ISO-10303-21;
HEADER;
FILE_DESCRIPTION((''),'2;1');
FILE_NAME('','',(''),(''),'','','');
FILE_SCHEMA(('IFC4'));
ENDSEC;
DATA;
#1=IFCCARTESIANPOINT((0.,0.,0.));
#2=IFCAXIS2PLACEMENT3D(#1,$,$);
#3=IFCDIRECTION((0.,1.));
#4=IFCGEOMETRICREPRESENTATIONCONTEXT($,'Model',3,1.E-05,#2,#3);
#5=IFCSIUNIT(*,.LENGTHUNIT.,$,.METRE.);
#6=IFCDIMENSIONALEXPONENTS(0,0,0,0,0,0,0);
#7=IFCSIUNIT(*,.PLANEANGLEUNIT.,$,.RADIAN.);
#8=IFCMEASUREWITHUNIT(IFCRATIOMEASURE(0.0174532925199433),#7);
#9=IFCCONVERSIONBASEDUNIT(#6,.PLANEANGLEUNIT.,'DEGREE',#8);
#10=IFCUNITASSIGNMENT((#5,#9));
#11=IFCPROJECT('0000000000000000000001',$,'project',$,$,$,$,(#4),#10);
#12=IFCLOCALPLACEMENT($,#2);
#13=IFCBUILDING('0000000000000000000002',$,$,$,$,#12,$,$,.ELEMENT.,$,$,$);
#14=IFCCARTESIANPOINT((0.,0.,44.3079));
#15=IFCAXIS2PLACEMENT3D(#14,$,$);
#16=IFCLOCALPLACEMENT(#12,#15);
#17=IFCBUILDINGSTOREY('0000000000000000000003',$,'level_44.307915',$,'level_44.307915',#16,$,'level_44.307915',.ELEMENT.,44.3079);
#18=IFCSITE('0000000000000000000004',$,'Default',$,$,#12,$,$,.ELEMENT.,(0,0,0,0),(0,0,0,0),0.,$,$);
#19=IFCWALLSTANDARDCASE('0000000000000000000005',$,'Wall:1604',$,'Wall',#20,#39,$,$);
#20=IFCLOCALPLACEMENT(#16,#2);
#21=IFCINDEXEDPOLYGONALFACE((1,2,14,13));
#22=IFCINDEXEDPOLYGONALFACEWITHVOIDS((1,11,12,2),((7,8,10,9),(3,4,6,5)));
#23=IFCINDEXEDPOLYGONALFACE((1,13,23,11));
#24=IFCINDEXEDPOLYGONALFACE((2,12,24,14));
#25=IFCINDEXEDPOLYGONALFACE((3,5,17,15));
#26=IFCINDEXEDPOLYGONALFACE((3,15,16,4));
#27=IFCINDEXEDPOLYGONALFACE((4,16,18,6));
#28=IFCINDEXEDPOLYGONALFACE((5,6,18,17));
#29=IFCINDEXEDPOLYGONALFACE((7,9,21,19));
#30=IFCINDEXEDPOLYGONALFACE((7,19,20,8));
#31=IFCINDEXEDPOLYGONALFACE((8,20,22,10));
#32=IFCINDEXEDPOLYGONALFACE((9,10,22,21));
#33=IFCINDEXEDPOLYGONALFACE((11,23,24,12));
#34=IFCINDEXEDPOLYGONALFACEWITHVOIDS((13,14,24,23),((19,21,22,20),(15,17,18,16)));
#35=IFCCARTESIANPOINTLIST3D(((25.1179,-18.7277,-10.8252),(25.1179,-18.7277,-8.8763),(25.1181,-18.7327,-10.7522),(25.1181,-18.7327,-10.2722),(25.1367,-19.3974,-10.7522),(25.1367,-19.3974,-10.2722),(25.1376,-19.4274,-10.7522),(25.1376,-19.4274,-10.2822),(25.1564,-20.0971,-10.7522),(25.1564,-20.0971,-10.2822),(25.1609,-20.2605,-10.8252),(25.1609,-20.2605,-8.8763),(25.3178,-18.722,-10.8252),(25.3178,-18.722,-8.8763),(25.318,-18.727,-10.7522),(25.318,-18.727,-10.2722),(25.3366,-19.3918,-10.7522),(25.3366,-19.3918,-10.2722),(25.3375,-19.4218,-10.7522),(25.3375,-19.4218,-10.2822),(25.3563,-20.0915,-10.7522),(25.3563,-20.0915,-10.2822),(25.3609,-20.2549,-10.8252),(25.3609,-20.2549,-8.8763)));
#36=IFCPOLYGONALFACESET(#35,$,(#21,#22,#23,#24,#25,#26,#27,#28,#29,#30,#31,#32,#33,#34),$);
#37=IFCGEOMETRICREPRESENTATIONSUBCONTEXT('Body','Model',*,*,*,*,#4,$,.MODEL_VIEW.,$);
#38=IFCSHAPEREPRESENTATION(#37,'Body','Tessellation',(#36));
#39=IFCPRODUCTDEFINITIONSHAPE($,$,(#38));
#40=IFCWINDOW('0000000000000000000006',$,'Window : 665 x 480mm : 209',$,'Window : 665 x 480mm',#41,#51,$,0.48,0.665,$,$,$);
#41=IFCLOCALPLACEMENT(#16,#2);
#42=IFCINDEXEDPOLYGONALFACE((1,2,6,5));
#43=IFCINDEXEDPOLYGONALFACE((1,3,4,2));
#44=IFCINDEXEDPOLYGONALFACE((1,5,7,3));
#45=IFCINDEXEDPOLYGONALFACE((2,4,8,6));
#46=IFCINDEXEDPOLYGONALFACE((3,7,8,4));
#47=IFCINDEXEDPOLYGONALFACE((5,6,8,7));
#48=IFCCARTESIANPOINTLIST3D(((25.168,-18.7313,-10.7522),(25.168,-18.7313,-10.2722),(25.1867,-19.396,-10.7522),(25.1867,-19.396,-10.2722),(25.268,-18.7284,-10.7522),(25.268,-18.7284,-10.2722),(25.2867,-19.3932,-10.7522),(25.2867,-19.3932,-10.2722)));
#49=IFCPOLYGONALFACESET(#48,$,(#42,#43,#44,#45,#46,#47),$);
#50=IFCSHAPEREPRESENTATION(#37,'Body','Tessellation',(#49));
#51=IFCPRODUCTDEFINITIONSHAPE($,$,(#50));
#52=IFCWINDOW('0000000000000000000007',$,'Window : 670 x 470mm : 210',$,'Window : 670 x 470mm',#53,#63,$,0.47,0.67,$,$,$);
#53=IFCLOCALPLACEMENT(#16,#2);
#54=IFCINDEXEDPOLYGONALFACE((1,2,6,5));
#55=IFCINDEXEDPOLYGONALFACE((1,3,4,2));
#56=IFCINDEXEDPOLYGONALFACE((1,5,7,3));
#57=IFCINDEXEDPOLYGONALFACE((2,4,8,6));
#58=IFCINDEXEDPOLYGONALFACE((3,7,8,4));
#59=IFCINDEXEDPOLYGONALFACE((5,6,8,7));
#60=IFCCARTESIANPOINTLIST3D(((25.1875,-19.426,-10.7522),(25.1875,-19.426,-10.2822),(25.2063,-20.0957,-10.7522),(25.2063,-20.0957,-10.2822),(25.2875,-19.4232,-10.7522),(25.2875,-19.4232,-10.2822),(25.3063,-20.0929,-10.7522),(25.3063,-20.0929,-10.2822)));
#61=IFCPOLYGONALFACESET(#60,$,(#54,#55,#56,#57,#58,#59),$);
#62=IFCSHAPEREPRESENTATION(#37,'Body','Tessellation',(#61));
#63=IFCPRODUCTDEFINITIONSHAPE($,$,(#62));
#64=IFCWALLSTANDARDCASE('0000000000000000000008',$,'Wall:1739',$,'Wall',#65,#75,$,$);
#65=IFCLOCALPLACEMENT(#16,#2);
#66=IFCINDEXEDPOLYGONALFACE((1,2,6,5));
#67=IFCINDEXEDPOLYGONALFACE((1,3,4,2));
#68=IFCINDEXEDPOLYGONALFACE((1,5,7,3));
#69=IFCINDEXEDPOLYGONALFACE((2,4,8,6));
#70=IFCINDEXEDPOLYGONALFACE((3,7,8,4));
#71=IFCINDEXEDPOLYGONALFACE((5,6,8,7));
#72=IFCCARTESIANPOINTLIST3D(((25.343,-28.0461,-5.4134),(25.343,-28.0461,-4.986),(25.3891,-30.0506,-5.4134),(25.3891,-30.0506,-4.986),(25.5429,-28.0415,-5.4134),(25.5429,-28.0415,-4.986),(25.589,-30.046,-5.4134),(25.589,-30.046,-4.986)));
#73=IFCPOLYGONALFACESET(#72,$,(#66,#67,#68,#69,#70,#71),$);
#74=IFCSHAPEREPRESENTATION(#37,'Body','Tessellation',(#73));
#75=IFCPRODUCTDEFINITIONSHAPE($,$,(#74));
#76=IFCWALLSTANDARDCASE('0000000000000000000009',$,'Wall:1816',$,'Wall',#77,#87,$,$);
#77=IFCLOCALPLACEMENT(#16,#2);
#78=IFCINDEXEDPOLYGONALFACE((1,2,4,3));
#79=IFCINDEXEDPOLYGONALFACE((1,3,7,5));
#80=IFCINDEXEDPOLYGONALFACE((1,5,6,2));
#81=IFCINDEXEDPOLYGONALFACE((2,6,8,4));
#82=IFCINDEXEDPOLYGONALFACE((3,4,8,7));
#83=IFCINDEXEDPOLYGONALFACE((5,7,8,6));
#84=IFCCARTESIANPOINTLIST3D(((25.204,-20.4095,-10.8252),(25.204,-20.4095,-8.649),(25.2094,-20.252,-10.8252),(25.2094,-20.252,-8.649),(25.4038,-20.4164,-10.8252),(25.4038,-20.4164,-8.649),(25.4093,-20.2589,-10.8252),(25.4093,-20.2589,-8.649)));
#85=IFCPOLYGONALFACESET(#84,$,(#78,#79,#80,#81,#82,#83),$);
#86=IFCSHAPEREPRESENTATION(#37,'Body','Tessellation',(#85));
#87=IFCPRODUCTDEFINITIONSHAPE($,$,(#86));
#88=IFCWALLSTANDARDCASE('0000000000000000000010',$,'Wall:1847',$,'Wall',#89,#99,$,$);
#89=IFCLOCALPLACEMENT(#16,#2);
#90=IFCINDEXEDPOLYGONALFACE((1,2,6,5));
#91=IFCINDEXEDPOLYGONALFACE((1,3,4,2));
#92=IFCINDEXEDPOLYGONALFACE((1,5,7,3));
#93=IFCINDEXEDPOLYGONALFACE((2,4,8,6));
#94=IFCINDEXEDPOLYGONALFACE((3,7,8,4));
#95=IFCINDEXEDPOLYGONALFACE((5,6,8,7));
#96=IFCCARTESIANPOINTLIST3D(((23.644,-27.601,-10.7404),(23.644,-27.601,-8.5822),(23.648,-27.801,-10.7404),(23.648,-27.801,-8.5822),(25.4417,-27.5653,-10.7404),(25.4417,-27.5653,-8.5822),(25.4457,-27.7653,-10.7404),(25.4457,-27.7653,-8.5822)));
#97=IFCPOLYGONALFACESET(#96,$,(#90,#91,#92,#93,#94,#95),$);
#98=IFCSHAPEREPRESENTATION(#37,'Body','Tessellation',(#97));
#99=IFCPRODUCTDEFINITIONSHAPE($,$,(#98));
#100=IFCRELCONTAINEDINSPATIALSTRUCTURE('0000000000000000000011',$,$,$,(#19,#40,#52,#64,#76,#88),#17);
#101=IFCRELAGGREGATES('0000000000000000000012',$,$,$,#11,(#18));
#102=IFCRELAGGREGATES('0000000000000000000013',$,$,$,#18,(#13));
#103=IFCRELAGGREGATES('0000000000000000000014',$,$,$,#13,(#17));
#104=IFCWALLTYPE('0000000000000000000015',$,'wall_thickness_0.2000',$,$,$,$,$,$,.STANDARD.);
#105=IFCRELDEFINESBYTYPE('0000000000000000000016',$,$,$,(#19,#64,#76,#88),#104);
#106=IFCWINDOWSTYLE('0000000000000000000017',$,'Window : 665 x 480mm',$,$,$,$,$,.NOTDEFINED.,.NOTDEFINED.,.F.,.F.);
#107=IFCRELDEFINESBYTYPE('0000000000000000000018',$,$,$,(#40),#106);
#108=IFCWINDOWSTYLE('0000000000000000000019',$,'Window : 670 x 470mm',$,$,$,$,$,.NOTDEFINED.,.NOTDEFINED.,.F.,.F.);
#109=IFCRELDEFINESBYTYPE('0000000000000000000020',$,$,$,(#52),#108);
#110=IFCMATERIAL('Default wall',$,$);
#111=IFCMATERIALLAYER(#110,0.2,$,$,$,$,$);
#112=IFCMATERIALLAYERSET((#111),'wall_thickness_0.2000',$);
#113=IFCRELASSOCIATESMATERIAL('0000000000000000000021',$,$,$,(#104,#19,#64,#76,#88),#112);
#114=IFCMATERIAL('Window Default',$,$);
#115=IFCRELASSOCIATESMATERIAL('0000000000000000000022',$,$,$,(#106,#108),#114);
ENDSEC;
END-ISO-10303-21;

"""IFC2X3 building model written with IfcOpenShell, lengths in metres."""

from ifc_helpers import new_model, entity, si_unit, converted_unit, direction, frame, frame_2d, origin, origin_2d_with_axis, place, context, subcontext, project, spatial, polyline, rectangle, outline, extrude, source, transform, mapped, material, layer, layer_set, layer_usage, type_object, type_shapes, element, fill, save


model = new_model("IFC2X3")

# Units and contexts
model_context = context("Model", 3, precision=1e-05, world=origin(), true_north=direction((0.0, 1.0)))
body_context = subcontext(model_context, "Body", "Model", "MODEL_VIEW")
ifc_project = project(units=[si_unit("LENGTHUNIT", "METRE"), converted_unit("PLANEANGLEUNIT", "DEGREE", entity("IfcRatioMeasure", 0.0174532925199433), si_unit("PLANEANGLEUNIT", "RADIAN"), dimensions=[0, 0, 0, 0, 0, 0, 0])], contexts=[model_context])

# Site, building, storey
placement_1 = place(None, origin())
site = spatial("IfcSite", under=ifc_project, at=placement_1, Name="Default", CompositionType="ELEMENT", RefLatitude=(0, 0, 0, 0), RefLongitude=(0, 0, 0, 0), RefElevation=0.0)
building = spatial("IfcBuilding", under=site, at=placement_1, CompositionType="ELEMENT")
storey_placement = place(placement_1, frame((0.0, 0.0, 44.3079)))
storey = spatial("IfcBuildingStorey", under=building, at=storey_placement, Name="level_44.307915", ObjectType="level_44.307915", LongName="level_44.307915", CompositionType="ELEMENT", Elevation=44.3079)

# Shared definitions
ifc_material_1 = material(Name="Default wall")
ifc_layer = layer(ifc_material_1, 0.2)
ifc_layer_set = layer_set([ifc_layer], Name="wall_thickness_0.2000")
ifc_layer_usage = layer_usage(ifc_layer_set, "AXIS2", "POSITIVE", -0.1)
wall_type = type_object("IfcWallType", Name="wall_thickness_0.2000", PredefinedType="STANDARD", material=ifc_layer_set)

# Shared definitions
ifc_material_2 = material(Name="Window Default")

# Wall, openings, windows
placement_2 = place(placement_1, frame((0.0, 0.0, 33.4827)))
wall_1_placement = place(placement_2, frame((25.2179, -18.7249, 0.0), z_axis=(0.0, 0.0, 1.0), x_axis=(0.028051, -0.999606, 0.0)))
wall_1 = element("IfcWallStandardCase", 1, at=wall_1_placement, inside=storey, type_object=wall_type, material=ifc_layer_usage, Name="Wall:1604", ObjectType="Wall", context=body_context, shape_type="SweptSolid", body=[
    extrude(outline(polyline([(1.5334, -0.1), (1.5334, 0.1), (0.0, 0.1), (0.0, -0.1), (1.5334, -0.1)])), origin(), (0.0, 0.0, 1.0), 1.9489),
])
opening_1_placement = place(wall_1_placement, frame((0.005, -0.1, 0.073)))
opening_1 = element("IfcOpeningElement", 2, at=opening_1_placement, cuts=wall_1, ObjectType="Opening", context=body_context, shape_type="SweptSolid", body=[
    extrude(rectangle(XDim=0.665, YDim=0.48, at=frame_2d((0.24, 0.3325), x_axis=(0.0, 1.0))), frame((0.0, 0.0, 0.0), z_axis=(0.0, 1.0, 0.0), x_axis=(0.0, 0.0, 1.0)), (0.0, 0.0, 1.0), 0.2),
])
opening_2_placement = place(wall_1_placement, frame((0.7, -0.1, 0.073)))
opening_2 = element("IfcOpeningElement", 3, at=opening_2_placement, cuts=wall_1, ObjectType="Opening", context=body_context, shape_type="SweptSolid", body=[
    extrude(rectangle(XDim=0.67, YDim=0.47, at=frame_2d((0.235, 0.335), x_axis=(0.0, 1.0))), frame((0.0, 0.0, 0.0), z_axis=(0.0, 1.0, 0.0), x_axis=(0.0, 0.0, 1.0)), (0.0, 0.0, 1.0), 0.2),
])
window_style_1 = type_object("IfcWindowStyle", Name="Window : 665 x 480mm", ConstructionType="NOTDEFINED", OperationType="NOTDEFINED", ParameterTakesPrecedence=False, Sizeable=False, material=ifc_material_2)
shared_shape_1 = source(origin(), body_context, "Body", "SweptSolid", [
    extrude(rectangle(XDim=0.1, YDim=0.665, at=origin_2d_with_axis()), frame((0.3325, 0.1, 0.0), z_axis=(0.0, 0.0, 1.0), x_axis=(0.0, 1.0, 0.0)), (0.0, 0.0, 1.0), 0.48),
])
type_shapes(window_style_1, [shared_shape_1])
window_1_placement = place(opening_1_placement, origin())
window_1 = element("IfcWindow", 4, at=window_1_placement, inside=storey, type_object=window_style_1, Name="Window : 665 x 480mm : 209", ObjectType="Window : 665 x 480mm", OverallHeight=0.48, OverallWidth=0.665, context=body_context, shape_type="MappedRepresentation", body=[
    mapped(shared_shape_1, transform((0.0, 0.0, 0.0), scale=1.0)),
])
fill(opening_1, window_1)
window_style_2 = type_object("IfcWindowStyle", Name="Window : 670 x 470mm", ConstructionType="NOTDEFINED", OperationType="NOTDEFINED", ParameterTakesPrecedence=False, Sizeable=False, material=ifc_material_2)
shared_shape_2 = source(origin(), body_context, "Body", "SweptSolid", [
    extrude(rectangle(XDim=0.1, YDim=0.67, at=origin_2d_with_axis()), frame((0.335, 0.1, 0.0), z_axis=(0.0, 0.0, 1.0), x_axis=(0.0, 1.0, 0.0)), (0.0, 0.0, 1.0), 0.47),
])
type_shapes(window_style_2, [shared_shape_2])
window_2_placement = place(opening_2_placement, origin())
window_2 = element("IfcWindow", 5, at=window_2_placement, inside=storey, type_object=window_style_2, Name="Window : 670 x 470mm : 210", ObjectType="Window : 670 x 470mm", OverallHeight=0.47, OverallWidth=0.67, context=body_context, shape_type="MappedRepresentation", body=[
    mapped(shared_shape_2, transform((0.0, 0.0, 0.0), scale=1.0)),
])
fill(opening_2, window_2)

# Walls
placement_3 = place(placement_1, frame((0.0, 0.0, 38.8945)))
wall_2_placement = place(placement_3, frame((25.4429, -28.0438, 0.0), z_axis=(0.0, 0.0, 1.0), x_axis=(0.023005, -0.999735, 0.0)))
element("IfcWallStandardCase", 6, at=wall_2_placement, inside=storey, type_object=wall_type, material=ifc_layer_usage, Name="Wall:1739", ObjectType="Wall", context=body_context, shape_type="SweptSolid", body=[
    extrude(outline(polyline([(2.005, -0.1), (2.005, 0.1), (0.0, 0.1), (0.0, -0.1), (2.005, -0.1)])), origin(), (0.0, 0.0, 1.0), 0.4274),
])
placement_4 = place(placement_1, frame((0.0, 0.0, 33.4827)))
wall_3_placement = place(placement_4, frame((25.3094, -20.2554, 0.0), z_axis=(0.0, 0.0, 1.0), x_axis=(-0.034601, -0.999401, 0.0)))
element("IfcWallStandardCase", 7, at=wall_3_placement, inside=storey, type_object=wall_type, material=ifc_layer_usage, Name="Wall:1816", ObjectType="Wall", context=body_context, shape_type="SweptSolid", body=[
    extrude(outline(polyline([(0.1576, -0.1), (0.1576, 0.1), (0.0, 0.1), (0.0, -0.1), (0.1576, -0.1)])), origin(), (0.0, 0.0, 1.0), 2.1761),
])
placement_5 = place(placement_1, frame((0.0, 0.0, 33.5675)))
wall_4_placement = place(placement_5, frame((25.4437, -27.6653, 0.0), z_axis=(0.0, 0.0, 1.0), x_axis=(-0.999803, -0.019852, 0.0)))
element("IfcWallStandardCase", 8, at=wall_4_placement, inside=storey, type_object=wall_type, material=ifc_layer_usage, Name="Wall:1847", ObjectType="Wall", context=body_context, shape_type="SweptSolid", body=[
    extrude(outline(polyline([(1.798, -0.1), (1.798, 0.1), (0.0, 0.1), (0.0, -0.1), (1.798, -0.1)])), origin(), (0.0, 0.0, 1.0), 2.1582),
])

save(model, "model.ifc")
